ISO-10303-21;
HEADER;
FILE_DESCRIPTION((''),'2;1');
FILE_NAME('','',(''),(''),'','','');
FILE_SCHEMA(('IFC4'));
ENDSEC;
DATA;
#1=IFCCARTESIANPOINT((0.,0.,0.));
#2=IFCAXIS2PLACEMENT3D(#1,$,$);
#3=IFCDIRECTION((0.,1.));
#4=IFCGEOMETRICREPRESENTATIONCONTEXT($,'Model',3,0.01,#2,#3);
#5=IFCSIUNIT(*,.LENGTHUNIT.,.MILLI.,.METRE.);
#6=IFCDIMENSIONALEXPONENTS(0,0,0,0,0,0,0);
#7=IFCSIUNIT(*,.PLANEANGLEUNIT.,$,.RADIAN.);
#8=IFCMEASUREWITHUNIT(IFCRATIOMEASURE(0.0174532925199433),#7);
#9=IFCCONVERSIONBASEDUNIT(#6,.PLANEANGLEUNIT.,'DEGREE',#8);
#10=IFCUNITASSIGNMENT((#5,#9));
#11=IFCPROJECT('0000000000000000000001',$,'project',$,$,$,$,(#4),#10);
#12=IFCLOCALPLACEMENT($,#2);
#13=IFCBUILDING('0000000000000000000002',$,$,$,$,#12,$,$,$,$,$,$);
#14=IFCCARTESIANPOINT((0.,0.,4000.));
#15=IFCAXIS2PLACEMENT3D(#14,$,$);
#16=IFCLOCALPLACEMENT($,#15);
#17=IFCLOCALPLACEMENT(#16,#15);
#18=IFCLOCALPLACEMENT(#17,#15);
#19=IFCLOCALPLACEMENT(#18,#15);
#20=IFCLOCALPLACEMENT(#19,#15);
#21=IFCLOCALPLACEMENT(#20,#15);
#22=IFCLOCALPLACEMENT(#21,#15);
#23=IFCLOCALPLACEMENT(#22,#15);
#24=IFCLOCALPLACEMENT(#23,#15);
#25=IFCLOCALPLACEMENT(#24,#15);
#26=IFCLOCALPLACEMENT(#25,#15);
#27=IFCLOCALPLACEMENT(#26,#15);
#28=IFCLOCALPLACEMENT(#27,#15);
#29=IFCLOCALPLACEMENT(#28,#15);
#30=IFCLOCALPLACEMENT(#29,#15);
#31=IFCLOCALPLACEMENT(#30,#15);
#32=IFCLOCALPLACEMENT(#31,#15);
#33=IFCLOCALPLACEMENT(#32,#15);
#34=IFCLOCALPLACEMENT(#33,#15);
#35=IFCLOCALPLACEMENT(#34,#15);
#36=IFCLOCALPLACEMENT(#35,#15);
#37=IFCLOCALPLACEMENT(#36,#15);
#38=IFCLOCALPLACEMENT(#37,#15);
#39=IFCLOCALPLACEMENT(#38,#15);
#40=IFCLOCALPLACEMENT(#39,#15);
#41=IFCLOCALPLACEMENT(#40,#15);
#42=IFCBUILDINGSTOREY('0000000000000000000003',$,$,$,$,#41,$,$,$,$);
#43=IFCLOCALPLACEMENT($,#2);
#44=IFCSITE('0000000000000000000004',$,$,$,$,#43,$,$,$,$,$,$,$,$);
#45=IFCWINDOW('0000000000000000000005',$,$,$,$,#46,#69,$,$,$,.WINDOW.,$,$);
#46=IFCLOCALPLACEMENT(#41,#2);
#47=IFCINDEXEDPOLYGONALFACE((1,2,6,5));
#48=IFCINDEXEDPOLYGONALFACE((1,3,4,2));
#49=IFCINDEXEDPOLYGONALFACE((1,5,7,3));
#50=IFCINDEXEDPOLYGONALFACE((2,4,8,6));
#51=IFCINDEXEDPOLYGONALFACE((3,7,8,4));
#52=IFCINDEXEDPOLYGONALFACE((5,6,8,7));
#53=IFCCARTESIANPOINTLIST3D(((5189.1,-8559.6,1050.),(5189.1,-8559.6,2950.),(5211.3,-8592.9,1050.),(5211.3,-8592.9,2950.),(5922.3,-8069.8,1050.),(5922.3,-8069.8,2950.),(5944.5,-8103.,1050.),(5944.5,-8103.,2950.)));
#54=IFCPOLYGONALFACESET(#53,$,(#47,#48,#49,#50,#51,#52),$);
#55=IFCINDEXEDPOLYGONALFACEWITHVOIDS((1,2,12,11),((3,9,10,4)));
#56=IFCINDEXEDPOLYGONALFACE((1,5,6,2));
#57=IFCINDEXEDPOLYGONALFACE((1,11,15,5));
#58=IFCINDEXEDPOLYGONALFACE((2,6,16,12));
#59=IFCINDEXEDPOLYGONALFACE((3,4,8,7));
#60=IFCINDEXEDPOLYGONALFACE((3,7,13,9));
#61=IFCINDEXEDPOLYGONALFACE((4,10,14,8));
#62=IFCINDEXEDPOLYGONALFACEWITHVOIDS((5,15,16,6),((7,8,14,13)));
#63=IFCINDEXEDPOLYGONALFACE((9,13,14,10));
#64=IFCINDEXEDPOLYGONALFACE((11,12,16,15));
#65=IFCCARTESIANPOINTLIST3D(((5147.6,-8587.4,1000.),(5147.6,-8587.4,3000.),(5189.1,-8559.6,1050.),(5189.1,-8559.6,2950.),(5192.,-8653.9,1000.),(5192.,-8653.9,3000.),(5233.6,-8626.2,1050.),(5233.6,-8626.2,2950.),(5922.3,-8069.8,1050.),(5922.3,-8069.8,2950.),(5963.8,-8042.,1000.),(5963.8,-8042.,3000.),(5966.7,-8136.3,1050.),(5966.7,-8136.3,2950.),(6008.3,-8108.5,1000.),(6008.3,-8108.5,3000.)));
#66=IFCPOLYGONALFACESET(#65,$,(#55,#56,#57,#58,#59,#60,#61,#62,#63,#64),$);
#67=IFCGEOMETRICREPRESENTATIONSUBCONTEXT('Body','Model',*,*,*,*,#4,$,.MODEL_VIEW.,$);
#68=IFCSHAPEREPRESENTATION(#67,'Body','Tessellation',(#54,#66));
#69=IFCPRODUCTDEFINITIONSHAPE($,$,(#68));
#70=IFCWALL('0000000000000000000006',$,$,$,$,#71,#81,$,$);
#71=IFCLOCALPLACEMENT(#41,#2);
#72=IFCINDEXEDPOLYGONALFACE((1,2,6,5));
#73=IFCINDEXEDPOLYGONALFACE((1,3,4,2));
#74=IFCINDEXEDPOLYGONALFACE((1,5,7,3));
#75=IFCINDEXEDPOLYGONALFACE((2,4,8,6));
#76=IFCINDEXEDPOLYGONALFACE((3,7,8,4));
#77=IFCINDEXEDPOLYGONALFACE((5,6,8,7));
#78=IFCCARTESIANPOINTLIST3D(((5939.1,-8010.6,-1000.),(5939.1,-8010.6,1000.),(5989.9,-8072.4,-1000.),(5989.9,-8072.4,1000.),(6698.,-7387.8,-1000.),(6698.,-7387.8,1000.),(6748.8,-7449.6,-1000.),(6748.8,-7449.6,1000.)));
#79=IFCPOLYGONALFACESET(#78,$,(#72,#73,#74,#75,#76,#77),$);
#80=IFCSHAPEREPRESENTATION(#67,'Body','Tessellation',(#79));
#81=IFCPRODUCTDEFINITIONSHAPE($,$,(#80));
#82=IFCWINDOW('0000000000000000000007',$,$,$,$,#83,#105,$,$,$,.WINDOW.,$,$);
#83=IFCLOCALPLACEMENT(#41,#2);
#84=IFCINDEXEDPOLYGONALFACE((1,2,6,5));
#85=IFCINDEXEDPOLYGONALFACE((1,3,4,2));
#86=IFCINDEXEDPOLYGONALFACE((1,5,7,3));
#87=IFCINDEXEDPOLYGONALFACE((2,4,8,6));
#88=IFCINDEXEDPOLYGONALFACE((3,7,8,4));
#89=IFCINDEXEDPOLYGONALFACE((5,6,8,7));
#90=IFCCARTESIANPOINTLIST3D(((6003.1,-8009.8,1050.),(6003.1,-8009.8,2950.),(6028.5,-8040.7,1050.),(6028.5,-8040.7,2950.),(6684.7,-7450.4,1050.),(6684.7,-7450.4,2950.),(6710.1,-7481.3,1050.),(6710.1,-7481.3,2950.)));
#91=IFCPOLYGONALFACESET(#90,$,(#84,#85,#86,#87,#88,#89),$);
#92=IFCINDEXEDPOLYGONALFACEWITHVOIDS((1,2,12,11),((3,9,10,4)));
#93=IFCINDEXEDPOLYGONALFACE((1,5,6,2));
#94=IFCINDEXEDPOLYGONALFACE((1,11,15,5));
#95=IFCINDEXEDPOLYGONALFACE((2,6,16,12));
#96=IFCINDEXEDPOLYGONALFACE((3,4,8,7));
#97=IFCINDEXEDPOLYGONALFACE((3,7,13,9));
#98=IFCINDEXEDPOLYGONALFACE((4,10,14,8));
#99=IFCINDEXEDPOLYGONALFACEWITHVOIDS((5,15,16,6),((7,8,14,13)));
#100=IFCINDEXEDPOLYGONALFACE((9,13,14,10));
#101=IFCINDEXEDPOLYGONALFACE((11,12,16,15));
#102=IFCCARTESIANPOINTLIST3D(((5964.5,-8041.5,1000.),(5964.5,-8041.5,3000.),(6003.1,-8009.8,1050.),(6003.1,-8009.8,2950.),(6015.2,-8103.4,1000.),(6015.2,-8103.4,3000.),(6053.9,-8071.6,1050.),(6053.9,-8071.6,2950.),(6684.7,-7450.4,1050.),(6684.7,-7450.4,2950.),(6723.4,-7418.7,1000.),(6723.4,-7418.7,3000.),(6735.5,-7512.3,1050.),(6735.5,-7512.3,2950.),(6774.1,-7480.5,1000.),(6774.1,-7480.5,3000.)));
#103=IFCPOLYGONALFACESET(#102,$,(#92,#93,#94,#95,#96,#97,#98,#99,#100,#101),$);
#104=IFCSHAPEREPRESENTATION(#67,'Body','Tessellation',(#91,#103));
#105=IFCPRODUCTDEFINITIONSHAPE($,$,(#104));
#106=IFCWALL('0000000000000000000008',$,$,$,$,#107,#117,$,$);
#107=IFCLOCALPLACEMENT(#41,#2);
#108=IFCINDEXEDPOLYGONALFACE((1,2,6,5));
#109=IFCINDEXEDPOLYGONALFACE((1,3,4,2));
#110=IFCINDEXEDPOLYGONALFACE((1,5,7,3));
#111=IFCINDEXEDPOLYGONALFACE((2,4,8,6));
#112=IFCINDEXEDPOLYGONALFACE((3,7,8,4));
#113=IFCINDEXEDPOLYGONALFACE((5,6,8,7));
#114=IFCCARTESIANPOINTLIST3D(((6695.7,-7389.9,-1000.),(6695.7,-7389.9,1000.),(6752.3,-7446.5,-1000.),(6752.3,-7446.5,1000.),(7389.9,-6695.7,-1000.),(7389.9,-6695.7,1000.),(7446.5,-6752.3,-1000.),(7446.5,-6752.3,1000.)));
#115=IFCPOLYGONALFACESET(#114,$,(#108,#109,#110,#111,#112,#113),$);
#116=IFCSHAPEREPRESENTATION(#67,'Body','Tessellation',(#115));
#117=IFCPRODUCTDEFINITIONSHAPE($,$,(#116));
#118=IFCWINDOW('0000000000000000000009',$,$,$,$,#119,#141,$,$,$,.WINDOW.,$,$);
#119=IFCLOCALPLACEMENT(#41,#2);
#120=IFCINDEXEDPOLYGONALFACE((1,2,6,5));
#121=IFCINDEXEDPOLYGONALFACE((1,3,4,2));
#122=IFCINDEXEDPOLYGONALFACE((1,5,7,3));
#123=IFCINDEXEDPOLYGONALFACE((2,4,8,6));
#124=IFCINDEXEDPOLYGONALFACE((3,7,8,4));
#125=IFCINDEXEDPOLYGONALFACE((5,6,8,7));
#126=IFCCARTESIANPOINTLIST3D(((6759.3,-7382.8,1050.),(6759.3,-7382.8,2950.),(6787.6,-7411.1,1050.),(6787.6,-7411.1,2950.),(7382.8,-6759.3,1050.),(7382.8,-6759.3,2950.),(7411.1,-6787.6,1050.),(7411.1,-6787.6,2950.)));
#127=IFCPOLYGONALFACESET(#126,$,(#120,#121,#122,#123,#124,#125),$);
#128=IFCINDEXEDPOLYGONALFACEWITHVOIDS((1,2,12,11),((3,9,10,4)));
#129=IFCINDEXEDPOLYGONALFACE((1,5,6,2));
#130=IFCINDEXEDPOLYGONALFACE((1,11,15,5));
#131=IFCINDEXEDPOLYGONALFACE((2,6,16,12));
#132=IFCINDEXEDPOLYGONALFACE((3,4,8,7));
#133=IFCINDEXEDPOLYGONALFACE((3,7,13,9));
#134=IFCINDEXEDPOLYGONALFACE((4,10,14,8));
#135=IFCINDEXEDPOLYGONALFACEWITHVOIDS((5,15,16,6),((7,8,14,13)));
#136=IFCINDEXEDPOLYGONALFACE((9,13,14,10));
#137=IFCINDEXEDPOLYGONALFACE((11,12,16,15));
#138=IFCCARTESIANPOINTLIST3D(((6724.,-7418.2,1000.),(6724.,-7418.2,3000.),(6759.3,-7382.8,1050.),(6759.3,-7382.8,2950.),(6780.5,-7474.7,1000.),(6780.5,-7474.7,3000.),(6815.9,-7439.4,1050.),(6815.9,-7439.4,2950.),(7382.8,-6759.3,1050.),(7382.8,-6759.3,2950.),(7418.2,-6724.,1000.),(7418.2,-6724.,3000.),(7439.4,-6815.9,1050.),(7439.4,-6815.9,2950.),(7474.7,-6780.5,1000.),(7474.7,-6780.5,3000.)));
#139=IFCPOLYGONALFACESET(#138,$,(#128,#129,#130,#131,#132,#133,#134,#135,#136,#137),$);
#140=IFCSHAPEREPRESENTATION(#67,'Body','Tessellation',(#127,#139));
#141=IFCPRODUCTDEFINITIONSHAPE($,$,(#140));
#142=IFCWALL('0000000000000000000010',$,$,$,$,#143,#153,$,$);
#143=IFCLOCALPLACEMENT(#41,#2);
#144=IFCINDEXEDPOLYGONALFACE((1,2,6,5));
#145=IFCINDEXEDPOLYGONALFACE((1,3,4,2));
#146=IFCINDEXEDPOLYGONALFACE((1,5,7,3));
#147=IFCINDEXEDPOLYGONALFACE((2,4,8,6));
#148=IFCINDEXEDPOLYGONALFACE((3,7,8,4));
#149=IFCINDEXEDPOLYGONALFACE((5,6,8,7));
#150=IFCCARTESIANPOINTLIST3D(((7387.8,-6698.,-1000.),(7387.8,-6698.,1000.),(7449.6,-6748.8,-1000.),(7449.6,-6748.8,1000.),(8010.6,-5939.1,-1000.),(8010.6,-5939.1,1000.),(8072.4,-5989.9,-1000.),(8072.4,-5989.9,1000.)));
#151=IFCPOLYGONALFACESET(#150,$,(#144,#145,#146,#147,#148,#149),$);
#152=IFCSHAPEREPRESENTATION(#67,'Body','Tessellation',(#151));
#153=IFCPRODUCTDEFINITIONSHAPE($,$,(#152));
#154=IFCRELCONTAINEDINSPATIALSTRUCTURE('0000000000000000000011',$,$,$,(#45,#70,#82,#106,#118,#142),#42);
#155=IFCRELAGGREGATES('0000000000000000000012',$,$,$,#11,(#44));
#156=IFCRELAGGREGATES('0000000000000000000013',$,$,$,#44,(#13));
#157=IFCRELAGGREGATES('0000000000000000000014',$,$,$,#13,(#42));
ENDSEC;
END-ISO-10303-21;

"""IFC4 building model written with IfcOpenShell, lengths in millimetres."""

from ifc_helpers import new_model, entity, si_unit, converted_unit, direction, frame, origin, origin_2d, place, context, subcontext, project, spatial, rectangle, extrude, element, save


model = new_model("IFC4")

# Units and contexts
model_context = context("Model", 3, precision=0.01, world=origin(), true_north=direction((0.0, 1.0)))
body_context = subcontext(model_context, "Body", "Model", "MODEL_VIEW")
ifc_project = project(units=[si_unit("LENGTHUNIT", "METRE", prefix="MILLI"), converted_unit("PLANEANGLEUNIT", "DEGREE", entity("IfcRatioMeasure", 0.0174532925199433), si_unit("PLANEANGLEUNIT", "RADIAN"), dimensions=[0, 0, 0, 0, 0, 0, 0])], contexts=[model_context])

# Site, building, storey
site_placement = place(None, origin())
site = spatial("IfcSite", under=ifc_project, at=site_placement)
building_placement = place(None, origin())
building = spatial("IfcBuilding", under=site, at=building_placement)
placement_1 = place(None, frame((0.0, 0.0, 4000.0)))
placement_2 = place(placement_1, frame((0.0, 0.0, 4000.0)))
placement_3 = place(placement_2, frame((0.0, 0.0, 4000.0)))
placement_4 = place(placement_3, frame((0.0, 0.0, 4000.0)))
placement_5 = place(placement_4, frame((0.0, 0.0, 4000.0)))
placement_6 = place(placement_5, frame((0.0, 0.0, 4000.0)))
placement_7 = place(placement_6, frame((0.0, 0.0, 4000.0)))
placement_8 = place(placement_7, frame((0.0, 0.0, 4000.0)))
placement_9 = place(placement_8, frame((0.0, 0.0, 4000.0)))
placement_10 = place(placement_9, frame((0.0, 0.0, 4000.0)))
placement_11 = place(placement_10, frame((0.0, 0.0, 4000.0)))
placement_12 = place(placement_11, frame((0.0, 0.0, 4000.0)))
placement_13 = place(placement_12, frame((0.0, 0.0, 4000.0)))
placement_14 = place(placement_13, frame((0.0, 0.0, 4000.0)))
placement_15 = place(placement_14, frame((0.0, 0.0, 4000.0)))
placement_16 = place(placement_15, frame((0.0, 0.0, 4000.0)))
placement_17 = place(placement_16, frame((0.0, 0.0, 4000.0)))
placement_18 = place(placement_17, frame((0.0, 0.0, 4000.0)))
placement_19 = place(placement_18, frame((0.0, 0.0, 4000.0)))
placement_20 = place(placement_19, frame((0.0, 0.0, 4000.0)))
placement_21 = place(placement_20, frame((0.0, 0.0, 4000.0)))
placement_22 = place(placement_21, frame((0.0, 0.0, 4000.0)))
placement_23 = place(placement_22, frame((0.0, 0.0, 4000.0)))
placement_24 = place(placement_23, frame((0.0, 0.0, 4000.0)))
placement_25 = place(placement_24, frame((0.0, 0.0, 4000.0)))
storey_placement = place(placement_25, frame((0.0, 0.0, 4000.0)))
storey = spatial("IfcBuildingStorey", under=building, at=storey_placement)

# Shared definitions
cartesian_point_1 = entity("IfcCartesianPoint", [-440.9, -950.0])
shared_polyline = entity("IfcPolyline", [cartesian_point_1, entity("IfcCartesianPoint", [-440.9, 950.0]), entity("IfcCartesianPoint", [-440.9, 950.0]), entity("IfcCartesianPoint", [440.9, 950.0]), entity("IfcCartesianPoint", [440.9, 950.0]), entity("IfcCartesianPoint", [440.9, -950.0]), entity("IfcCartesianPoint", [440.9, -950.0]), entity("IfcCartesianPoint", [-440.9, -950.0]), cartesian_point_1])

# Window
window_1_placement = place(storey_placement, frame((5555.7, -8314.7, 2000.0), z_axis=(0.0, 0.0, 1.0), x_axis=(8314.697373, 5555.700459, 0.0)))
cartesian_point_2 = entity("IfcCartesianPoint", [-490.9, -1000.0])
element("IfcWindow", 1, at=window_1_placement, inside=storey, PredefinedType="WINDOW", context=body_context, shape_type="SweptSolid", body=[
    entity("IfcExtrudedAreaSolid", entity("IfcArbitraryClosedProfileDef", "AREA", None, shared_polyline), entity("IfcAxis2Placement3D", entity("IfcCartesianPoint", [0.0, 0.0, 0.0]), entity("IfcDirection", [0.0, -1.0, 0.0]), entity("IfcDirection", [1.0, 0.0, 0.0])), entity("IfcDirection", [0.0, 0.0, 1.0]), 40.0),
    entity("IfcExtrudedAreaSolid", entity("IfcArbitraryProfileDefWithVoids", "AREA", None, entity("IfcPolyline", [cartesian_point_2, entity("IfcCartesianPoint", [-490.9, 1000.0]), entity("IfcCartesianPoint", [-490.9, 1000.0]), entity("IfcCartesianPoint", [490.9, 1000.0]), entity("IfcCartesianPoint", [490.9, 1000.0]), entity("IfcCartesianPoint", [490.9, -1000.0]), entity("IfcCartesianPoint", [490.9, -1000.0]), entity("IfcCartesianPoint", [-490.9, -1000.0]), cartesian_point_2]), [shared_polyline]), entity("IfcAxis2Placement3D", entity("IfcCartesianPoint", [0.0, 0.0, 0.0]), entity("IfcDirection", [0.0, -1.0, 0.0]), entity("IfcDirection", [1.0, 0.0, 0.0])), entity("IfcDirection", [0.0, 0.0, 1.0]), 80.0),
])

# Wall
wall_1_placement = place(storey_placement, frame((6343.9, -7730.1, -1000.0), z_axis=(0.0, 0.0, 1.0), x_axis=(7730.104195, 6343.933254, 0.0)))
element("IfcWall", 2, at=wall_1_placement, inside=storey, context=body_context, shape_type="SweptSolid", body=[
    extrude(rectangle(XDim=981.7, YDim=80.0, at=origin_2d()), origin(), (0.0, 0.0, 1.0), 2000.0),
])

# Window
window_2_placement = place(storey_placement, frame((6343.9, -7730.1, 2000.0), z_axis=(0.0, 0.0, 1.0), x_axis=(7730.104195, 6343.933254, 0.0)))
cartesian_point_3 = entity("IfcCartesianPoint", [-490.9, -1000.0])
element("IfcWindow", 3, at=window_2_placement, inside=storey, PredefinedType="WINDOW", context=body_context, shape_type="SweptSolid", body=[
    entity("IfcExtrudedAreaSolid", entity("IfcArbitraryClosedProfileDef", "AREA", None, shared_polyline), entity("IfcAxis2Placement3D", entity("IfcCartesianPoint", [0.0, 0.0, 0.0]), entity("IfcDirection", [0.0, -1.0, 0.0]), entity("IfcDirection", [1.0, 0.0, 0.0])), entity("IfcDirection", [0.0, 0.0, 1.0]), 40.0),
    entity("IfcExtrudedAreaSolid", entity("IfcArbitraryProfileDefWithVoids", "AREA", None, entity("IfcPolyline", [cartesian_point_3, entity("IfcCartesianPoint", [-490.9, 1000.0]), entity("IfcCartesianPoint", [-490.9, 1000.0]), entity("IfcCartesianPoint", [490.9, 1000.0]), entity("IfcCartesianPoint", [490.9, 1000.0]), entity("IfcCartesianPoint", [490.9, -1000.0]), entity("IfcCartesianPoint", [490.9, -1000.0]), entity("IfcCartesianPoint", [-490.9, -1000.0]), cartesian_point_3]), [shared_polyline]), entity("IfcAxis2Placement3D", entity("IfcCartesianPoint", [0.0, 0.0, 0.0]), entity("IfcDirection", [0.0, -1.0, 0.0]), entity("IfcDirection", [1.0, 0.0, 0.0])), entity("IfcDirection", [0.0, 0.0, 1.0]), 80.0),
])

# Wall
wall_2_placement = place(storey_placement, frame((7071.1, -7071.1, -1000.0), z_axis=(0.0, 0.0, 1.0), x_axis=(7071.068837, 7071.066786, 0.0)))
element("IfcWall", 4, at=wall_2_placement, inside=storey, context=body_context, shape_type="SweptSolid", body=[
    extrude(rectangle(XDim=981.7, YDim=80.0, at=origin_2d()), origin(), (0.0, 0.0, 1.0), 2000.0),
])

# Window
window_3_placement = place(storey_placement, frame((7071.1, -7071.1, 2000.0), z_axis=(0.0, 0.0, 1.0), x_axis=(7071.068837, 7071.066786, 0.0)))
cartesian_point_4 = entity("IfcCartesianPoint", [-490.9, -1000.0])
element("IfcWindow", 5, at=window_3_placement, inside=storey, PredefinedType="WINDOW", context=body_context, shape_type="SweptSolid", body=[
    entity("IfcExtrudedAreaSolid", entity("IfcArbitraryClosedProfileDef", "AREA", None, shared_polyline), entity("IfcAxis2Placement3D", entity("IfcCartesianPoint", [0.0, 0.0, 0.0]), entity("IfcDirection", [0.0, -1.0, 0.0]), entity("IfcDirection", [1.0, 0.0, 0.0])), entity("IfcDirection", [0.0, 0.0, 1.0]), 40.0),
    entity("IfcExtrudedAreaSolid", entity("IfcArbitraryProfileDefWithVoids", "AREA", None, entity("IfcPolyline", [cartesian_point_4, entity("IfcCartesianPoint", [-490.9, 1000.0]), entity("IfcCartesianPoint", [-490.9, 1000.0]), entity("IfcCartesianPoint", [490.9, 1000.0]), entity("IfcCartesianPoint", [490.9, 1000.0]), entity("IfcCartesianPoint", [490.9, -1000.0]), entity("IfcCartesianPoint", [490.9, -1000.0]), entity("IfcCartesianPoint", [-490.9, -1000.0]), cartesian_point_4]), [shared_polyline]), entity("IfcAxis2Placement3D", entity("IfcCartesianPoint", [0.0, 0.0, 0.0]), entity("IfcDirection", [0.0, -1.0, 0.0]), entity("IfcDirection", [1.0, 0.0, 0.0])), entity("IfcDirection", [0.0, 0.0, 1.0]), 80.0),
])

# Wall
wall_3_placement = place(storey_placement, frame((7730.1, -6343.9, -1000.0), z_axis=(0.0, 0.0, 1.0), x_axis=(6343.931811, 7730.10538, 0.0)))
element("IfcWall", 6, at=wall_3_placement, inside=storey, context=body_context, shape_type="SweptSolid", body=[
    extrude(rectangle(XDim=981.7, YDim=80.0, at=origin_2d()), origin(), (0.0, 0.0, 1.0), 2000.0),
])

save(model, "model.ifc")
